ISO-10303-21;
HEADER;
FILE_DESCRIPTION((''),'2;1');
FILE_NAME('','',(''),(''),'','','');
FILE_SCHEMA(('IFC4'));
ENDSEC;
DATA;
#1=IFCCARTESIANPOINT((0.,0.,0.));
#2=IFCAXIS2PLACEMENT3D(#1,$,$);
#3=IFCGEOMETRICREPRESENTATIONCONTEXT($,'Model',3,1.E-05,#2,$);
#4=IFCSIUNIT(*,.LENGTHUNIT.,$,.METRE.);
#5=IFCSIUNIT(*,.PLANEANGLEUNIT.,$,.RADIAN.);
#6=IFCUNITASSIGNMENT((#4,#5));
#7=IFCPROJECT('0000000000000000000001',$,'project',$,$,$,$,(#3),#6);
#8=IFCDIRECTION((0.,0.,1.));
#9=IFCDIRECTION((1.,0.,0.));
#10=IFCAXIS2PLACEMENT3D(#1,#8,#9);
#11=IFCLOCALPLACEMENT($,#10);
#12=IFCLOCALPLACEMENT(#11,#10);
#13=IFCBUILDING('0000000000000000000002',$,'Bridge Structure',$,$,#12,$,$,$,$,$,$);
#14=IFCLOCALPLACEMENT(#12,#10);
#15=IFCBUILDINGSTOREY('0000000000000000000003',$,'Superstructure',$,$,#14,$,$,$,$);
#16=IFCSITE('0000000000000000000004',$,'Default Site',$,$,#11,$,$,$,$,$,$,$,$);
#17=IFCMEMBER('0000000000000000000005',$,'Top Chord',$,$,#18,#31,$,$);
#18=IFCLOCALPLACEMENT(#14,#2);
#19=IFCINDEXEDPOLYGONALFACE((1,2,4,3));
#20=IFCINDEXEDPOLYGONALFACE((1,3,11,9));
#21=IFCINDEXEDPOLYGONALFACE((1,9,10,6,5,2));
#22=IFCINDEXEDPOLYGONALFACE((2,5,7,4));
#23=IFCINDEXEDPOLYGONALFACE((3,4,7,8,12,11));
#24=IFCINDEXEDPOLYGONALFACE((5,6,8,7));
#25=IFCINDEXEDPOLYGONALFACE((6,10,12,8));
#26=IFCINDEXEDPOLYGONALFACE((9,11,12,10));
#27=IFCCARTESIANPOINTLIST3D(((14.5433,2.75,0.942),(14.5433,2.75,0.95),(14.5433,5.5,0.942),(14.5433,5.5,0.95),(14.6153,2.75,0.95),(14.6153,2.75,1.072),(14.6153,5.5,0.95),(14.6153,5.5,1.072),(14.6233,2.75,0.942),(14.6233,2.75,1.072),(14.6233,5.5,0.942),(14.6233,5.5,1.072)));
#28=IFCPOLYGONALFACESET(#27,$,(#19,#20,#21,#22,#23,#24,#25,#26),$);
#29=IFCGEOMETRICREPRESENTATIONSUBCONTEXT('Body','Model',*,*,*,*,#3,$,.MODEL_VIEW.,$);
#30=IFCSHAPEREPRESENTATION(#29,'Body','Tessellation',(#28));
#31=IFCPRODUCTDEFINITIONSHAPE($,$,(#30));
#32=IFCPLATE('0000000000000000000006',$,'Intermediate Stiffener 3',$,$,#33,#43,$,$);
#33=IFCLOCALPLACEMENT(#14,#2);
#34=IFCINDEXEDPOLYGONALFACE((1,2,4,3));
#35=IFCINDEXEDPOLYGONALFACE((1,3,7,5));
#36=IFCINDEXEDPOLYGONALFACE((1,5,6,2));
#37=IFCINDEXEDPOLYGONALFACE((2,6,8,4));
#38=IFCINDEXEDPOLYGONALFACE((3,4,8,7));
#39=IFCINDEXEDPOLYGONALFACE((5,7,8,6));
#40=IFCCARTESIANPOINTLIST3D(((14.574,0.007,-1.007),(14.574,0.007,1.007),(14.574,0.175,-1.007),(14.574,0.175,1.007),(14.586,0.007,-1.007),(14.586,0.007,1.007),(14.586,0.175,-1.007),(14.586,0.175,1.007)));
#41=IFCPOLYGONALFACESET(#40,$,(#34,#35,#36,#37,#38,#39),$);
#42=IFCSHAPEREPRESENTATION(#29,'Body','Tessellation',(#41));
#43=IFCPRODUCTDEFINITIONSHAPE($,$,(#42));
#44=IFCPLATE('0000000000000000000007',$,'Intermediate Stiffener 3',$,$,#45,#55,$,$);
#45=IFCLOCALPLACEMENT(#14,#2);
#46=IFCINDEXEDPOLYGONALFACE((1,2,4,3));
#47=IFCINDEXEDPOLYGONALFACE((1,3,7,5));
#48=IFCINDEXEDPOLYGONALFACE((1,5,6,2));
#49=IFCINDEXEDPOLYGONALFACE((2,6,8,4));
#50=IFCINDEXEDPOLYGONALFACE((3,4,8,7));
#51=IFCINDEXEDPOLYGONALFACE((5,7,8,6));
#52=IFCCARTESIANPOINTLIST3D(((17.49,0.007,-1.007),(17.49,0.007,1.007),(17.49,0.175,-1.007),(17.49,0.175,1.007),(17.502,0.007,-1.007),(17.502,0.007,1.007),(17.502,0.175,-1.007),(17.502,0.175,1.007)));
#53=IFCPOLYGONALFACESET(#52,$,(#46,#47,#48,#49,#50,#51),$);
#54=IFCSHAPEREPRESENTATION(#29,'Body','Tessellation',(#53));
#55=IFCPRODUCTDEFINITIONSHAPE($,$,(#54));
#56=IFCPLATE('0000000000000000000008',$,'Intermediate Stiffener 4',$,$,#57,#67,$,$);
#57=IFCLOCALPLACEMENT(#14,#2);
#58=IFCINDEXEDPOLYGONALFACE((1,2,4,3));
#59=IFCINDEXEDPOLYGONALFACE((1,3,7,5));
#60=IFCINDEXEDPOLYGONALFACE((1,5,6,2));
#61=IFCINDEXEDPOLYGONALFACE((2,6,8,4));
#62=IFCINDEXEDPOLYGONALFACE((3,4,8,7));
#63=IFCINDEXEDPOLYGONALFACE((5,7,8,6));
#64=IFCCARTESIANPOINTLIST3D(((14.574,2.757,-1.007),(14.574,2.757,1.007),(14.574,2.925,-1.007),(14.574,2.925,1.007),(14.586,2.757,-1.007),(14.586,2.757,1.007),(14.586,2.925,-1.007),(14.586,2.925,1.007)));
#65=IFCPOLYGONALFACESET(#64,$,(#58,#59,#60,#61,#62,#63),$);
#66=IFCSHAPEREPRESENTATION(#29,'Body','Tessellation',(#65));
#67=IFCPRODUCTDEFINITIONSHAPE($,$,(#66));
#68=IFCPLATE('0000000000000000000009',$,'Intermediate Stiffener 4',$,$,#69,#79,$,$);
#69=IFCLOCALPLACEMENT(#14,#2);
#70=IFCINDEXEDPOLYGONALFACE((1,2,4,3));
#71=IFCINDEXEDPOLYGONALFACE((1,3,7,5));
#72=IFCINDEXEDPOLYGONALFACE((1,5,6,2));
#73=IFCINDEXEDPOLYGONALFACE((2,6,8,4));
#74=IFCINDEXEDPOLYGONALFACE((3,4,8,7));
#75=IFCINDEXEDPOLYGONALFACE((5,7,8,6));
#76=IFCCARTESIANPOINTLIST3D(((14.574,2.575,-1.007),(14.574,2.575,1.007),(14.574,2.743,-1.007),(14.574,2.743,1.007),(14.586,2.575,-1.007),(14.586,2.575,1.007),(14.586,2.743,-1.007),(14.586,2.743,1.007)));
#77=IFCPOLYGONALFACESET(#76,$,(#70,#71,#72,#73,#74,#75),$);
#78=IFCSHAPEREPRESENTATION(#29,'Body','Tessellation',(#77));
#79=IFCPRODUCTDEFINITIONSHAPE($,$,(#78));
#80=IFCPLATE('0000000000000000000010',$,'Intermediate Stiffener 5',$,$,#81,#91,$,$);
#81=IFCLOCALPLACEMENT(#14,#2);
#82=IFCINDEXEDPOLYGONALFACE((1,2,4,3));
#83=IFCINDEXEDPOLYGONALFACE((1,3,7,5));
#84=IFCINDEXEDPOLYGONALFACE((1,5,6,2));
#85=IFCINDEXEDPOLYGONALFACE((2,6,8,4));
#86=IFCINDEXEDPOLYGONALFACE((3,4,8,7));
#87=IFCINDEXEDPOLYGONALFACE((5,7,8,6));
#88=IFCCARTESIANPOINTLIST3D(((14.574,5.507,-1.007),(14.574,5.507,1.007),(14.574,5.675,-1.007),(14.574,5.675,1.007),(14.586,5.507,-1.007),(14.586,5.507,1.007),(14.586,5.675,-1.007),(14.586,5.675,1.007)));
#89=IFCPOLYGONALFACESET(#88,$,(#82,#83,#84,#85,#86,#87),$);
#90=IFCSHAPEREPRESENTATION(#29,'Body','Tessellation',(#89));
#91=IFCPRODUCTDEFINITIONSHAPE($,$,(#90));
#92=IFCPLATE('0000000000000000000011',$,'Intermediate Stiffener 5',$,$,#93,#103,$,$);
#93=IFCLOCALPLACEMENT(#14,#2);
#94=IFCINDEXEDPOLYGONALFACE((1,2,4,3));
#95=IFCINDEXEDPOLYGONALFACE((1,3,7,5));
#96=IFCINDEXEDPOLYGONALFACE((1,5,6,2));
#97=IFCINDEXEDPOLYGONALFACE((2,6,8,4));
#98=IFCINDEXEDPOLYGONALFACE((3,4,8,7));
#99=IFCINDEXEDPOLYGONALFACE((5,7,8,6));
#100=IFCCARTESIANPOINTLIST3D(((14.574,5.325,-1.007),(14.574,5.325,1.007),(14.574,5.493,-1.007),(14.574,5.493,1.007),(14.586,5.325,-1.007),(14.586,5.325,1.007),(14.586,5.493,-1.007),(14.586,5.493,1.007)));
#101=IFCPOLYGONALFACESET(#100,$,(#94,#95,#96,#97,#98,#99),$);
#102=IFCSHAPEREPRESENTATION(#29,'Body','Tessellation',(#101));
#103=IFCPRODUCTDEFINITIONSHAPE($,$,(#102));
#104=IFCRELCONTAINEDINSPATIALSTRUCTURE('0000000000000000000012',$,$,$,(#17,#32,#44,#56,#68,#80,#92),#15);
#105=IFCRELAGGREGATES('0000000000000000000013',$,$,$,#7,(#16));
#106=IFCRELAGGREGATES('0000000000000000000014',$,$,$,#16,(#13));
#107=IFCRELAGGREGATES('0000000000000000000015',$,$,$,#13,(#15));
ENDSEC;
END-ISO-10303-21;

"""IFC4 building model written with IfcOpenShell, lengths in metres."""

from ifc_helpers import new_model, si_unit, frame, origin, origin_with_axes, origin_2d_with_axis, place, context, subcontext, project, spatial, rectangle, l_section, extrude, element, save


model = new_model("IFC4")

# Units and contexts
model_context = context("Model", 3, precision=1e-05, world=origin())
body_context = subcontext(model_context, "Body", "Model", "MODEL_VIEW")
ifc_project = project(units=[si_unit("LENGTHUNIT", "METRE"), si_unit("PLANEANGLEUNIT", "RADIAN")], contexts=[model_context])

# Site, building, storey
site_placement = place(None, origin_with_axes())
site = spatial("IfcSite", under=ifc_project, at=site_placement, Name="Default Site")
building_placement = place(site_placement, origin_with_axes())
building = spatial("IfcBuilding", under=site, at=building_placement, Name="Bridge Structure")
storey_placement = place(building_placement, origin_with_axes())
storey = spatial("IfcBuildingStorey", under=building, at=storey_placement, Name="Superstructure")

# Member
for number, where, z_axis, x_axis, name in (
    (1, (14.5833, 2.75, 1.007), (0.0, 1.0, 0.0), (-1.0, 0.0, 0.0), "Top Chord"),
):
    element("IfcMember", number, at=place(storey_placement, frame(where, z_axis=z_axis, x_axis=x_axis)), inside=storey, Name=name, context=body_context, shape_type="SweptSolid", body=[
        extrude(l_section(Depth=0.13, Width=0.08, Thickness=0.008, at=origin_2d_with_axis()), origin_with_axes(), (0.0, 0.0, 1.0), 2.75),
    ])

# Plates
for number, where, z_axis, x_axis, name in (
    (2, (14.58, 0.091, -1.007), (0.0, 0.0, 1.0), (1.0, 0.0, 0.0), "Intermediate Stiffener 3"),
    (3, (17.496, 0.091, -1.007), (0.0, 0.0, 1.0), (1.0, 0.0, 0.0), "Intermediate Stiffener 3"),
    (4, (14.58, 2.841, -1.007), (0.0, 0.0, 1.0), (1.0, 0.0, 0.0), "Intermediate Stiffener 4"),
    (5, (14.58, 2.659, -1.007), (0.0, 0.0, 1.0), (1.0, 0.0, 0.0), "Intermediate Stiffener 4"),
    (6, (14.58, 5.591, -1.007), (0.0, 0.0, 1.0), (1.0, 0.0, 0.0), "Intermediate Stiffener 5"),
    (7, (14.58, 5.409, -1.007), (0.0, 0.0, 1.0), (1.0, 0.0, 0.0), "Intermediate Stiffener 5"),
):
    element("IfcPlate", number, at=place(storey_placement, frame(where, z_axis=z_axis, x_axis=x_axis)), inside=storey, Name=name, context=body_context, shape_type="SweptSolid", body=[
        extrude(rectangle(XDim=0.012, YDim=0.168, at=origin_2d_with_axis()), origin_with_axes(), (0.0, 0.0, 1.0), 2.014),
    ])

save(model, "model.ifc")
